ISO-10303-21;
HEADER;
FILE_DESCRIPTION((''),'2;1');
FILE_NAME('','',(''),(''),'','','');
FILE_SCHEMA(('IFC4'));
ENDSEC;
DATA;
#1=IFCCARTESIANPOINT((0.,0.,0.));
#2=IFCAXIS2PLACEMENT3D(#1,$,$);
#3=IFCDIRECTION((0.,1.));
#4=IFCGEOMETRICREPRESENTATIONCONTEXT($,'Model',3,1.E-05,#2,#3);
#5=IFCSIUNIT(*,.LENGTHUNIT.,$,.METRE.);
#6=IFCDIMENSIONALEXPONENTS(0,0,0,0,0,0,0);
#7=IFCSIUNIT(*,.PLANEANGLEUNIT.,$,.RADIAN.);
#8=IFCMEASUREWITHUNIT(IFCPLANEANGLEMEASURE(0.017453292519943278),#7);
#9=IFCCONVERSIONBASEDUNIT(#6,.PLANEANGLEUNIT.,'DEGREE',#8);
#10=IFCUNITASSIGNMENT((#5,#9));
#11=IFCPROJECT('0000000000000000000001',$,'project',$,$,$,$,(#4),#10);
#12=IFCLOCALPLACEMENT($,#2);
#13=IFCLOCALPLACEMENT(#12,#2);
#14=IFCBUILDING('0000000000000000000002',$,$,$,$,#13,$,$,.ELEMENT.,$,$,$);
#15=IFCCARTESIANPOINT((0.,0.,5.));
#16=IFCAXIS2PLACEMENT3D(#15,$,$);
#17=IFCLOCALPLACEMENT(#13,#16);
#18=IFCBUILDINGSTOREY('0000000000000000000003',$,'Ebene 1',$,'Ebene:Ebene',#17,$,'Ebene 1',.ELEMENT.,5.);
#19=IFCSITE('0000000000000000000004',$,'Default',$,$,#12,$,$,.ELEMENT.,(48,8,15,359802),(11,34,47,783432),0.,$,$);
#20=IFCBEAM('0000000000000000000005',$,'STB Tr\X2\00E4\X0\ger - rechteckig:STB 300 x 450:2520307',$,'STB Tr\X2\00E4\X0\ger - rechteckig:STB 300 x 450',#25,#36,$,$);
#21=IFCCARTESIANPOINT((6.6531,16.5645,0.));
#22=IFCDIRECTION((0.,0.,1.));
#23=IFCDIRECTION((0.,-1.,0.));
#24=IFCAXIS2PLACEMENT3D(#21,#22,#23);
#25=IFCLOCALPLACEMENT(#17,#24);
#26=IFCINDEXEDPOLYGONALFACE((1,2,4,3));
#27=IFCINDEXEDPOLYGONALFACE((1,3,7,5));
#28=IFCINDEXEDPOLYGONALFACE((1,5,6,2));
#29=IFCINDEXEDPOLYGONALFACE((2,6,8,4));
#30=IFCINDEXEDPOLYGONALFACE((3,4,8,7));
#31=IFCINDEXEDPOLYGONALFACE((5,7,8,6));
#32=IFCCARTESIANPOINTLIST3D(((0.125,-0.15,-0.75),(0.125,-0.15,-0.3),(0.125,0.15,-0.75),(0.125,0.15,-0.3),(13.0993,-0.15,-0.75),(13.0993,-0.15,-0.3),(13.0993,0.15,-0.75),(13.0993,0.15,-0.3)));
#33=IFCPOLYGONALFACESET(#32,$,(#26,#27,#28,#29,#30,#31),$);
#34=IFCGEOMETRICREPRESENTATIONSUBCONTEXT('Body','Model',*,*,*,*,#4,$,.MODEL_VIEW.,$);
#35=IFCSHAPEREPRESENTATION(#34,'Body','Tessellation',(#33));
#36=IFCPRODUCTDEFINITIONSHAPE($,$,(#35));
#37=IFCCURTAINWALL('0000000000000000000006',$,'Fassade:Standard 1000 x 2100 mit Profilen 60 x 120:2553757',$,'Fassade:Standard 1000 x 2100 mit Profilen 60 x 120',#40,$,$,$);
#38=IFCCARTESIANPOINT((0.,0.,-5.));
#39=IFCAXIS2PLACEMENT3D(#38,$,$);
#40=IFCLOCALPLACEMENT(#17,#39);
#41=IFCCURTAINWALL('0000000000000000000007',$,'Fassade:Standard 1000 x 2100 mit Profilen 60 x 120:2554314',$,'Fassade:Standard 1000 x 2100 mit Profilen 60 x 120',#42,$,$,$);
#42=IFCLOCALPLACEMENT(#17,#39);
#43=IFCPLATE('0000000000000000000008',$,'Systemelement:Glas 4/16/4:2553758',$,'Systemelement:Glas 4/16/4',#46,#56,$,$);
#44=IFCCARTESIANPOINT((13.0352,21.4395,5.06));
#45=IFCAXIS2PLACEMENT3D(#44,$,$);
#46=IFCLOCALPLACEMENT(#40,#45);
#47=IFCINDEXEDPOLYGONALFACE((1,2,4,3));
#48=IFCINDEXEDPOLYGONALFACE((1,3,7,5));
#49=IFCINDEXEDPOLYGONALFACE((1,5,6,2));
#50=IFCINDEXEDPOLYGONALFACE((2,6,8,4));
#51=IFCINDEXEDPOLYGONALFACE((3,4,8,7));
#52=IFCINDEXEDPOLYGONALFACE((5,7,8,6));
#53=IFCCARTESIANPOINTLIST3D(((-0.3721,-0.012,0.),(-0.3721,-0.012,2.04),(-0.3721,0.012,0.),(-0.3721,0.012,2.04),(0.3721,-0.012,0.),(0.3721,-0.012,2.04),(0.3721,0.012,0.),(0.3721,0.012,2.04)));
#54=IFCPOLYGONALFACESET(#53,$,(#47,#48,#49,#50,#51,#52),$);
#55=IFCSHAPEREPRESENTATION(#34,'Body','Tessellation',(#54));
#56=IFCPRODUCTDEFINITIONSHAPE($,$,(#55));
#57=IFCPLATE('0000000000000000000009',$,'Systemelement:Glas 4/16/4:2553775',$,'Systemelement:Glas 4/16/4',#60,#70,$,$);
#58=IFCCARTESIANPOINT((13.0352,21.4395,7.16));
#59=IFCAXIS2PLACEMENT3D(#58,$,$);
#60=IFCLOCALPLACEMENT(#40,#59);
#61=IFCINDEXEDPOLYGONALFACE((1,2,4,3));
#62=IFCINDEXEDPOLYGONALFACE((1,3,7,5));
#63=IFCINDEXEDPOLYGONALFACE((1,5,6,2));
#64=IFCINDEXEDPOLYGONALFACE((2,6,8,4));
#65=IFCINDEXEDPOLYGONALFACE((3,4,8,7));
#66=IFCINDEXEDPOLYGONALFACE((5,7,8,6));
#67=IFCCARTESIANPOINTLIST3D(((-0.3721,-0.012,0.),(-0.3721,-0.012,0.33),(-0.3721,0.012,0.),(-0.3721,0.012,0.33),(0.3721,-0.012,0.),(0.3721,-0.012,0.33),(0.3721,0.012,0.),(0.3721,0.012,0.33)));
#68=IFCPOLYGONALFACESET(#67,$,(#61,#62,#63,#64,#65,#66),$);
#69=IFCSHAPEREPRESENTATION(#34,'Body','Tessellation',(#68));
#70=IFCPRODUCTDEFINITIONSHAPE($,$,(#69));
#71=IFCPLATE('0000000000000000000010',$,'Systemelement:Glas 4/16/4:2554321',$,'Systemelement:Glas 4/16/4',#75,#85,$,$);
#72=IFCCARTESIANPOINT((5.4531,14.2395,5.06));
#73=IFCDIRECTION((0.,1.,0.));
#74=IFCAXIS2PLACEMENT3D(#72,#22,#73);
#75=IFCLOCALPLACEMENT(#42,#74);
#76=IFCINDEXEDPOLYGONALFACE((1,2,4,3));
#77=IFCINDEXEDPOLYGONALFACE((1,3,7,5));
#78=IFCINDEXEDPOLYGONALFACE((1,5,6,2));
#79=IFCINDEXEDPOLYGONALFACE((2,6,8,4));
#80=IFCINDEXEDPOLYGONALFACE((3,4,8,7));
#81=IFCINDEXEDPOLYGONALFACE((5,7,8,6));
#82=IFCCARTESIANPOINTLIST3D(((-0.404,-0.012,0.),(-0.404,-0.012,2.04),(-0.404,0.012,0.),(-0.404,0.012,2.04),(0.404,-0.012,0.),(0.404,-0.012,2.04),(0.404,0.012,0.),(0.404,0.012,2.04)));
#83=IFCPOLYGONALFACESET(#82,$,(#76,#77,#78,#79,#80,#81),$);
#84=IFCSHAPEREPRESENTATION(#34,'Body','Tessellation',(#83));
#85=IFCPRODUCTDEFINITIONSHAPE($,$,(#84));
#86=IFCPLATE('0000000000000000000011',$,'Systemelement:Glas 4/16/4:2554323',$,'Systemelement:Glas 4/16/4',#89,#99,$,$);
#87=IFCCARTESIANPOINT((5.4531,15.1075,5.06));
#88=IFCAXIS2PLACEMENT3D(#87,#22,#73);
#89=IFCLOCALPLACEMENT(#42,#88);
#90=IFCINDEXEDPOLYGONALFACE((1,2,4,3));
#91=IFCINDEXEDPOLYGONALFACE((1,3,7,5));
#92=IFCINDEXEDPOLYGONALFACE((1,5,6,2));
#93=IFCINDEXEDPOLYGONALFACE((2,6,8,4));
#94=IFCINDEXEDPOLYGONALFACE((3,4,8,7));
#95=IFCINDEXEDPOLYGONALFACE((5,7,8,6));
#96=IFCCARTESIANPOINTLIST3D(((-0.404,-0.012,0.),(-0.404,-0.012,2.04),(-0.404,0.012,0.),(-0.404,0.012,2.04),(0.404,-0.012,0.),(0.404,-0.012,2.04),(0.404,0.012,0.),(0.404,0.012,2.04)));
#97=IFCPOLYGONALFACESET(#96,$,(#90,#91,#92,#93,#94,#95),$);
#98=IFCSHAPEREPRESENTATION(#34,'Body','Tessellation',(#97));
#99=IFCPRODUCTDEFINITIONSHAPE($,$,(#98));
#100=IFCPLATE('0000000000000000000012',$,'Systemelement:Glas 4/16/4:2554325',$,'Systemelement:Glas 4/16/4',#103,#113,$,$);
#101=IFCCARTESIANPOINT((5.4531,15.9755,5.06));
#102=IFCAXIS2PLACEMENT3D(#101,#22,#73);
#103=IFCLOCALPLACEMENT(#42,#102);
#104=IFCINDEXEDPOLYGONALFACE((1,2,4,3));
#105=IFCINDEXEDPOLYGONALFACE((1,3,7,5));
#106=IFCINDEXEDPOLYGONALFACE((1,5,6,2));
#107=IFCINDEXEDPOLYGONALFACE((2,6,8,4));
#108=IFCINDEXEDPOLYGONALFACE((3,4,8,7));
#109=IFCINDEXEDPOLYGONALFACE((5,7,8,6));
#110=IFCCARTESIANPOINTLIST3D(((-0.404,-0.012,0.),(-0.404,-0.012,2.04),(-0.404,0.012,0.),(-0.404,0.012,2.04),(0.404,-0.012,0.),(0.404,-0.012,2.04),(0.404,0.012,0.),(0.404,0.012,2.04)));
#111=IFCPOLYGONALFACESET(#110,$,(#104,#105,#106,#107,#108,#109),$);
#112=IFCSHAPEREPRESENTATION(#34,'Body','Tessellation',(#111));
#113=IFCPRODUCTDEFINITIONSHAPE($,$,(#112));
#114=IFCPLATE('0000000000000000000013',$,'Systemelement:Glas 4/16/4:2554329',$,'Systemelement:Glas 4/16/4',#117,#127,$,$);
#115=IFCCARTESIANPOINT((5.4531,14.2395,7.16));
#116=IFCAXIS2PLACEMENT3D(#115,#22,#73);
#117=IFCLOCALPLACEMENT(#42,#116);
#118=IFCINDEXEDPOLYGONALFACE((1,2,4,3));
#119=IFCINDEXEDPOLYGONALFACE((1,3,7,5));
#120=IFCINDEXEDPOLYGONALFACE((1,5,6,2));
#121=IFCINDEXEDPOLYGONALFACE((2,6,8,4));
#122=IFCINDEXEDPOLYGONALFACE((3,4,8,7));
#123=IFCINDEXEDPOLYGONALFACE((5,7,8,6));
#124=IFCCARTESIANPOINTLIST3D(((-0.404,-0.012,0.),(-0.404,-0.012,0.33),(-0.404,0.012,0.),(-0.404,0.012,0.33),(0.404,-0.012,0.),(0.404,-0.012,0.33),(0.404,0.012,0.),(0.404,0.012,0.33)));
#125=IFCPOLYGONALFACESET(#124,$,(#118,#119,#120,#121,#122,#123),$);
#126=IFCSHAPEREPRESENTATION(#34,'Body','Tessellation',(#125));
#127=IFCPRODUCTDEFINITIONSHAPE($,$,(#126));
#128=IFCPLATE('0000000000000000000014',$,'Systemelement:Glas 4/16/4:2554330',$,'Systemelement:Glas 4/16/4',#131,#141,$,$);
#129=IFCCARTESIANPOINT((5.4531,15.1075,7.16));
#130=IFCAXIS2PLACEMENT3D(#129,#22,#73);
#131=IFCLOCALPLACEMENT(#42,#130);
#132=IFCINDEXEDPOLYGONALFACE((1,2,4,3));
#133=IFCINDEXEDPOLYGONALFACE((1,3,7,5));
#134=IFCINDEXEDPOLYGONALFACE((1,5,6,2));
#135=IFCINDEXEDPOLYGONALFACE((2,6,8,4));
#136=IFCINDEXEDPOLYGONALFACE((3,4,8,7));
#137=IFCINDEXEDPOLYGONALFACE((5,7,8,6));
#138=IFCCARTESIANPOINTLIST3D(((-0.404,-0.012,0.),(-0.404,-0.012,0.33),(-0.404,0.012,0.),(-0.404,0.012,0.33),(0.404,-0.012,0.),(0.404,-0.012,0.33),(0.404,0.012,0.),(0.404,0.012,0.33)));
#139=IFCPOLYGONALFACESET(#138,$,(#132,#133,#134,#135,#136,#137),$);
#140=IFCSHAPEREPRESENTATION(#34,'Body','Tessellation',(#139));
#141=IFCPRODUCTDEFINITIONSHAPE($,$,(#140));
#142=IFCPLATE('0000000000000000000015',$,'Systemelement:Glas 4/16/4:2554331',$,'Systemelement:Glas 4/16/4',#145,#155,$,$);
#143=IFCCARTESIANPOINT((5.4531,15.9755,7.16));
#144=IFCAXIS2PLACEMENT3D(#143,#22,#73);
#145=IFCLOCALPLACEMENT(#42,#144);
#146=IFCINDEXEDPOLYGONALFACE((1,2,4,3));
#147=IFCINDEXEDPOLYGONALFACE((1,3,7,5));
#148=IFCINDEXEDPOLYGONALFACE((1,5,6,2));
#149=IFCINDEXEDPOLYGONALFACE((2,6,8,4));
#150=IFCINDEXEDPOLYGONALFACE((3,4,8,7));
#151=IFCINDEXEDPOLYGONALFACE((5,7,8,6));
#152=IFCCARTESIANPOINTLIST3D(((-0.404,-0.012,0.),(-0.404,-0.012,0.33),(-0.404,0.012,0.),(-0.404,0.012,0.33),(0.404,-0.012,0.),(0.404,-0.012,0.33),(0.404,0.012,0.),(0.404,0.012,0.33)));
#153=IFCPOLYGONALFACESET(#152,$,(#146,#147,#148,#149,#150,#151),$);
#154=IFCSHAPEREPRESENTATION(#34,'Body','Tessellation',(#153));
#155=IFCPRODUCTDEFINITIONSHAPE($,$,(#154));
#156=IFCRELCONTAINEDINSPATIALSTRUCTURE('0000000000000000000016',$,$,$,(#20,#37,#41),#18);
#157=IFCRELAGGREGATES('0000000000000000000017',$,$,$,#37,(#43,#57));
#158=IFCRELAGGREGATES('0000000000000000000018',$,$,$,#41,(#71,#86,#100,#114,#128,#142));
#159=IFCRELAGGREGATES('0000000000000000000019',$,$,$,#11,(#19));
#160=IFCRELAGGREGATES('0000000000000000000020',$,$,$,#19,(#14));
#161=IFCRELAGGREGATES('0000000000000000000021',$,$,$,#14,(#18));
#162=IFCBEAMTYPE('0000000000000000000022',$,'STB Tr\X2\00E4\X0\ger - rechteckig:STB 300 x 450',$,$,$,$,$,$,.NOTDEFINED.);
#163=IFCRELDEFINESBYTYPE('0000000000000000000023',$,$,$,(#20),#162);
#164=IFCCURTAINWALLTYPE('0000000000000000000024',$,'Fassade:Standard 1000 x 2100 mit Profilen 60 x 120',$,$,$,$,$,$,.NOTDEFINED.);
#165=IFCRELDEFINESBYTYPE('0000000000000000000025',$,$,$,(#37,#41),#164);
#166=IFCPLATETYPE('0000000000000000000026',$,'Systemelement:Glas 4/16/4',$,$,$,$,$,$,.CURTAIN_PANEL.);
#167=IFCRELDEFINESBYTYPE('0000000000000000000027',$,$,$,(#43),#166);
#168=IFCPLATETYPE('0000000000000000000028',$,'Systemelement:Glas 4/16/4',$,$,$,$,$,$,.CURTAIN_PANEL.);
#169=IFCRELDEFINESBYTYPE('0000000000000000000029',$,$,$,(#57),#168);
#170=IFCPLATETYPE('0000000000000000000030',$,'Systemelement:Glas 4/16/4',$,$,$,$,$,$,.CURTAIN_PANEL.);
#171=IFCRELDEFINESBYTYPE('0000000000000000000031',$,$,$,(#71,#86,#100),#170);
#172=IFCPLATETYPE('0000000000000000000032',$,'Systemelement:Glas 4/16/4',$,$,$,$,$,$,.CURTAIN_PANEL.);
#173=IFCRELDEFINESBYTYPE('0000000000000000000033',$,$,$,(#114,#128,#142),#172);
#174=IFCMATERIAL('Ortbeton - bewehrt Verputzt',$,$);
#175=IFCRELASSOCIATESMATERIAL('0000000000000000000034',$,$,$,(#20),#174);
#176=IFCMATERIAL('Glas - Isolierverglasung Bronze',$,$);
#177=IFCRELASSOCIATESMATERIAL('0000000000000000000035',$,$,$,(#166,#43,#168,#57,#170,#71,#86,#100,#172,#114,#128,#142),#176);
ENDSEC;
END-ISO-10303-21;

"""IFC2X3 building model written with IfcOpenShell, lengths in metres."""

from ifc_helpers import new_model, entity, si_unit, converted_unit, direction, frame, frame_2d, origin, origin_2d_with_axis, place, context, subcontext, project, spatial, rectangle, extrude, source, transform, mapped, material, type_object, type_shapes, element, aggregate, save


model = new_model("IFC2X3")

# Units and contexts
model_context = context("Model", 3, precision=1e-05, world=origin(), true_north=direction((0.0, 1.0)))
body_context = subcontext(model_context, "Body", "Model", "MODEL_VIEW")
ifc_project = project(units=[si_unit("LENGTHUNIT", "METRE"), converted_unit("PLANEANGLEUNIT", "DEGREE", entity("IfcPlaneAngleMeasure", 0.017453292519943278), si_unit("PLANEANGLEUNIT", "RADIAN"), dimensions=[0, 0, 0, 0, 0, 0, 0])], contexts=[model_context])

# Site, building, storey
site_placement = place(None, origin())
site = spatial("IfcSite", under=ifc_project, at=site_placement, Name="Default", CompositionType="ELEMENT", RefLatitude=(48, 8, 15, 359802), RefLongitude=(11, 34, 47, 783432), RefElevation=0.0)
building_placement = place(site_placement, origin())
building = spatial("IfcBuilding", under=site, at=building_placement, CompositionType="ELEMENT")
storey_placement = place(building_placement, frame((0.0, 0.0, 5.0)))
storey = spatial("IfcBuildingStorey", under=building, at=storey_placement, Name="Ebene 1", ObjectType="Ebene:Ebene", LongName="Ebene 1", CompositionType="ELEMENT", Elevation=5.0)

# Beam
ifc_material_1 = material(Name="Ortbeton - bewehrt Verputzt")
beam_type = type_object("IfcBeamType", Name="STB Träger - rechteckig:STB 300 x 450", PredefinedType="NOTDEFINED")
beam_1_placement = place(storey_placement, frame((6.6531, 16.5645, 0.0), z_axis=(0.0, 0.0, 1.0), x_axis=(0.0, -1.0, 0.0)))
element("IfcBeam", 1, at=beam_1_placement, inside=storey, type_object=beam_type, material=ifc_material_1, Name="STB Träger - rechteckig:STB 300 x 450:2520307", ObjectType="STB Träger - rechteckig:STB 300 x 450", context=body_context, shape_type="SweptSolid", body=[
    extrude(rectangle(XDim=0.45, YDim=0.3, at=frame_2d((0.0, 0.0), x_axis=(1.0, 0.0))), frame((0.125, 0.0, -0.525), z_axis=(1.0, 0.0, 0.0), x_axis=(0.0, 0.0, -1.0)), (0.0, 0.0, 1.0), 12.9743),
])

# Curtain walls
curtain_wall_type = type_object("IfcCurtainWallType", Name="Fassade:Standard 1000 x 2100 mit Profilen 60 x 120", PredefinedType="NOTDEFINED")
curtain_wall_1_placement = place(storey_placement, frame((0.0, 0.0, -5.0)))
curtain_wall_1 = element("IfcCurtainWall", 2, at=curtain_wall_1_placement, inside=storey, type_object=curtain_wall_type, Name="Fassade:Standard 1000 x 2100 mit Profilen 60 x 120:2553757", ObjectType="Fassade:Standard 1000 x 2100 mit Profilen 60 x 120")
curtain_wall_2_placement = place(storey_placement, frame((0.0, 0.0, -5.0)))
curtain_wall_2 = element("IfcCurtainWall", 3, at=curtain_wall_2_placement, inside=storey, type_object=curtain_wall_type, Name="Fassade:Standard 1000 x 2100 mit Profilen 60 x 120:2554314", ObjectType="Fassade:Standard 1000 x 2100 mit Profilen 60 x 120")

# Plates
ifc_material_2 = material(Name="Glas - Isolierverglasung Bronze")
plate_type_1 = type_object("IfcPlateType", Name="Systemelement:Glas 4/16/4", PredefinedType="CURTAIN_PANEL", material=ifc_material_2)
shared_shape_1 = source(origin(), body_context, "Body", "SweptSolid", [
    extrude(rectangle(XDim=0.024, YDim=0.7443, at=origin_2d_with_axis()), frame((0.0, 0.0, 0.0), z_axis=(0.0, 0.0, 1.0), x_axis=(0.0, 1.0, 0.0)), (0.0, 0.0, 1.0), 2.04),
])
type_shapes(plate_type_1, [shared_shape_1])
plate_1_placement = place(curtain_wall_1_placement, frame((13.0352, 21.4395, 5.06)))
plate_1 = element("IfcPlate", 4, at=plate_1_placement, type_object=plate_type_1, material=ifc_material_2, Name="Systemelement:Glas 4/16/4:2553758", ObjectType="Systemelement:Glas 4/16/4", context=body_context, shape_type="MappedRepresentation", body=[
    mapped(shared_shape_1, transform((0.0, 0.0, 0.0), scale=1.0)),
])
plate_type_2 = type_object("IfcPlateType", Name="Systemelement:Glas 4/16/4", PredefinedType="CURTAIN_PANEL", material=ifc_material_2)
shared_shape_2 = source(origin(), body_context, "Body", "SweptSolid", [
    extrude(rectangle(XDim=0.024, YDim=0.7443, at=origin_2d_with_axis()), frame((0.0, 0.0, 0.0), z_axis=(0.0, 0.0, 1.0), x_axis=(0.0, 1.0, 0.0)), (0.0, 0.0, 1.0), 0.33),
])
type_shapes(plate_type_2, [shared_shape_2])
plate_2_placement = place(curtain_wall_1_placement, frame((13.0352, 21.4395, 7.16)))
plate_2 = element("IfcPlate", 5, at=plate_2_placement, type_object=plate_type_2, material=ifc_material_2, Name="Systemelement:Glas 4/16/4:2553775", ObjectType="Systemelement:Glas 4/16/4", context=body_context, shape_type="MappedRepresentation", body=[
    mapped(shared_shape_2, transform((0.0, 0.0, 0.0), scale=1.0)),
])
aggregate(curtain_wall_1, [plate_1, plate_2])
plate_type_3 = type_object("IfcPlateType", Name="Systemelement:Glas 4/16/4", PredefinedType="CURTAIN_PANEL", material=ifc_material_2)
shared_shape_3 = source(origin(), body_context, "Body", "SweptSolid", [
    extrude(rectangle(XDim=0.024, YDim=0.808, at=origin_2d_with_axis()), frame((0.0, 0.0, 0.0), z_axis=(0.0, 0.0, 1.0), x_axis=(0.0, 1.0, 0.0)), (0.0, 0.0, 1.0), 2.04),
])
type_shapes(plate_type_3, [shared_shape_3])
plate_3_placement = place(curtain_wall_2_placement, frame((5.4531, 14.2395, 5.06), z_axis=(0.0, 0.0, 1.0), x_axis=(0.0, 1.0, 0.0)))
plate_3 = element("IfcPlate", 6, at=plate_3_placement, type_object=plate_type_3, material=ifc_material_2, Name="Systemelement:Glas 4/16/4:2554321", ObjectType="Systemelement:Glas 4/16/4", context=body_context, shape_type="MappedRepresentation", body=[
    mapped(shared_shape_3, transform((0.0, 0.0, 0.0), scale=1.0)),
])
plate_4_placement = place(curtain_wall_2_placement, frame((5.4531, 15.1075, 5.06), z_axis=(0.0, 0.0, 1.0), x_axis=(0.0, 1.0, 0.0)))
plate_4 = element("IfcPlate", 7, at=plate_4_placement, type_object=plate_type_3, material=ifc_material_2, Name="Systemelement:Glas 4/16/4:2554323", ObjectType="Systemelement:Glas 4/16/4", context=body_context, shape_type="MappedRepresentation", body=[
    mapped(shared_shape_3, transform((0.0, 0.0, 0.0), scale=1.0)),
])
plate_5_placement = place(curtain_wall_2_placement, frame((5.4531, 15.9755, 5.06), z_axis=(0.0, 0.0, 1.0), x_axis=(0.0, 1.0, 0.0)))
plate_5 = element("IfcPlate", 8, at=plate_5_placement, type_object=plate_type_3, material=ifc_material_2, Name="Systemelement:Glas 4/16/4:2554325", ObjectType="Systemelement:Glas 4/16/4", context=body_context, shape_type="MappedRepresentation", body=[
    mapped(shared_shape_3, transform((0.0, 0.0, 0.0), scale=1.0)),
])
plate_type_4 = type_object("IfcPlateType", Name="Systemelement:Glas 4/16/4", PredefinedType="CURTAIN_PANEL", material=ifc_material_2)
shared_shape_4 = source(origin(), body_context, "Body", "SweptSolid", [
    extrude(rectangle(XDim=0.024, YDim=0.808, at=origin_2d_with_axis()), frame((0.0, 0.0, 0.0), z_axis=(0.0, 0.0, 1.0), x_axis=(0.0, 1.0, 0.0)), (0.0, 0.0, 1.0), 0.33),
])
type_shapes(plate_type_4, [shared_shape_4])
plate_6_placement = place(curtain_wall_2_placement, frame((5.4531, 14.2395, 7.16), z_axis=(0.0, 0.0, 1.0), x_axis=(0.0, 1.0, 0.0)))
plate_6 = element("IfcPlate", 9, at=plate_6_placement, type_object=plate_type_4, material=ifc_material_2, Name="Systemelement:Glas 4/16/4:2554329", ObjectType="Systemelement:Glas 4/16/4", context=body_context, shape_type="MappedRepresentation", body=[
    mapped(shared_shape_4, transform((0.0, 0.0, 0.0), scale=1.0)),
])
plate_7_placement = place(curtain_wall_2_placement, frame((5.4531, 15.1075, 7.16), z_axis=(0.0, 0.0, 1.0), x_axis=(0.0, 1.0, 0.0)))
plate_7 = element("IfcPlate", 10, at=plate_7_placement, type_object=plate_type_4, material=ifc_material_2, Name="Systemelement:Glas 4/16/4:2554330", ObjectType="Systemelement:Glas 4/16/4", context=body_context, shape_type="MappedRepresentation", body=[
    mapped(shared_shape_4, transform((0.0, 0.0, 0.0), scale=1.0)),
])
plate_8_placement = place(curtain_wall_2_placement, frame((5.4531, 15.9755, 7.16), z_axis=(0.0, 0.0, 1.0), x_axis=(0.0, 1.0, 0.0)))
plate_8 = element("IfcPlate", 11, at=plate_8_placement, type_object=plate_type_4, material=ifc_material_2, Name="Systemelement:Glas 4/16/4:2554331", ObjectType="Systemelement:Glas 4/16/4", context=body_context, shape_type="MappedRepresentation", body=[
    mapped(shared_shape_4, transform((0.0, 0.0, 0.0), scale=1.0)),
])
aggregate(curtain_wall_2, [plate_3, plate_4, plate_5, plate_6, plate_7, plate_8])

save(model, "model.ifc")
